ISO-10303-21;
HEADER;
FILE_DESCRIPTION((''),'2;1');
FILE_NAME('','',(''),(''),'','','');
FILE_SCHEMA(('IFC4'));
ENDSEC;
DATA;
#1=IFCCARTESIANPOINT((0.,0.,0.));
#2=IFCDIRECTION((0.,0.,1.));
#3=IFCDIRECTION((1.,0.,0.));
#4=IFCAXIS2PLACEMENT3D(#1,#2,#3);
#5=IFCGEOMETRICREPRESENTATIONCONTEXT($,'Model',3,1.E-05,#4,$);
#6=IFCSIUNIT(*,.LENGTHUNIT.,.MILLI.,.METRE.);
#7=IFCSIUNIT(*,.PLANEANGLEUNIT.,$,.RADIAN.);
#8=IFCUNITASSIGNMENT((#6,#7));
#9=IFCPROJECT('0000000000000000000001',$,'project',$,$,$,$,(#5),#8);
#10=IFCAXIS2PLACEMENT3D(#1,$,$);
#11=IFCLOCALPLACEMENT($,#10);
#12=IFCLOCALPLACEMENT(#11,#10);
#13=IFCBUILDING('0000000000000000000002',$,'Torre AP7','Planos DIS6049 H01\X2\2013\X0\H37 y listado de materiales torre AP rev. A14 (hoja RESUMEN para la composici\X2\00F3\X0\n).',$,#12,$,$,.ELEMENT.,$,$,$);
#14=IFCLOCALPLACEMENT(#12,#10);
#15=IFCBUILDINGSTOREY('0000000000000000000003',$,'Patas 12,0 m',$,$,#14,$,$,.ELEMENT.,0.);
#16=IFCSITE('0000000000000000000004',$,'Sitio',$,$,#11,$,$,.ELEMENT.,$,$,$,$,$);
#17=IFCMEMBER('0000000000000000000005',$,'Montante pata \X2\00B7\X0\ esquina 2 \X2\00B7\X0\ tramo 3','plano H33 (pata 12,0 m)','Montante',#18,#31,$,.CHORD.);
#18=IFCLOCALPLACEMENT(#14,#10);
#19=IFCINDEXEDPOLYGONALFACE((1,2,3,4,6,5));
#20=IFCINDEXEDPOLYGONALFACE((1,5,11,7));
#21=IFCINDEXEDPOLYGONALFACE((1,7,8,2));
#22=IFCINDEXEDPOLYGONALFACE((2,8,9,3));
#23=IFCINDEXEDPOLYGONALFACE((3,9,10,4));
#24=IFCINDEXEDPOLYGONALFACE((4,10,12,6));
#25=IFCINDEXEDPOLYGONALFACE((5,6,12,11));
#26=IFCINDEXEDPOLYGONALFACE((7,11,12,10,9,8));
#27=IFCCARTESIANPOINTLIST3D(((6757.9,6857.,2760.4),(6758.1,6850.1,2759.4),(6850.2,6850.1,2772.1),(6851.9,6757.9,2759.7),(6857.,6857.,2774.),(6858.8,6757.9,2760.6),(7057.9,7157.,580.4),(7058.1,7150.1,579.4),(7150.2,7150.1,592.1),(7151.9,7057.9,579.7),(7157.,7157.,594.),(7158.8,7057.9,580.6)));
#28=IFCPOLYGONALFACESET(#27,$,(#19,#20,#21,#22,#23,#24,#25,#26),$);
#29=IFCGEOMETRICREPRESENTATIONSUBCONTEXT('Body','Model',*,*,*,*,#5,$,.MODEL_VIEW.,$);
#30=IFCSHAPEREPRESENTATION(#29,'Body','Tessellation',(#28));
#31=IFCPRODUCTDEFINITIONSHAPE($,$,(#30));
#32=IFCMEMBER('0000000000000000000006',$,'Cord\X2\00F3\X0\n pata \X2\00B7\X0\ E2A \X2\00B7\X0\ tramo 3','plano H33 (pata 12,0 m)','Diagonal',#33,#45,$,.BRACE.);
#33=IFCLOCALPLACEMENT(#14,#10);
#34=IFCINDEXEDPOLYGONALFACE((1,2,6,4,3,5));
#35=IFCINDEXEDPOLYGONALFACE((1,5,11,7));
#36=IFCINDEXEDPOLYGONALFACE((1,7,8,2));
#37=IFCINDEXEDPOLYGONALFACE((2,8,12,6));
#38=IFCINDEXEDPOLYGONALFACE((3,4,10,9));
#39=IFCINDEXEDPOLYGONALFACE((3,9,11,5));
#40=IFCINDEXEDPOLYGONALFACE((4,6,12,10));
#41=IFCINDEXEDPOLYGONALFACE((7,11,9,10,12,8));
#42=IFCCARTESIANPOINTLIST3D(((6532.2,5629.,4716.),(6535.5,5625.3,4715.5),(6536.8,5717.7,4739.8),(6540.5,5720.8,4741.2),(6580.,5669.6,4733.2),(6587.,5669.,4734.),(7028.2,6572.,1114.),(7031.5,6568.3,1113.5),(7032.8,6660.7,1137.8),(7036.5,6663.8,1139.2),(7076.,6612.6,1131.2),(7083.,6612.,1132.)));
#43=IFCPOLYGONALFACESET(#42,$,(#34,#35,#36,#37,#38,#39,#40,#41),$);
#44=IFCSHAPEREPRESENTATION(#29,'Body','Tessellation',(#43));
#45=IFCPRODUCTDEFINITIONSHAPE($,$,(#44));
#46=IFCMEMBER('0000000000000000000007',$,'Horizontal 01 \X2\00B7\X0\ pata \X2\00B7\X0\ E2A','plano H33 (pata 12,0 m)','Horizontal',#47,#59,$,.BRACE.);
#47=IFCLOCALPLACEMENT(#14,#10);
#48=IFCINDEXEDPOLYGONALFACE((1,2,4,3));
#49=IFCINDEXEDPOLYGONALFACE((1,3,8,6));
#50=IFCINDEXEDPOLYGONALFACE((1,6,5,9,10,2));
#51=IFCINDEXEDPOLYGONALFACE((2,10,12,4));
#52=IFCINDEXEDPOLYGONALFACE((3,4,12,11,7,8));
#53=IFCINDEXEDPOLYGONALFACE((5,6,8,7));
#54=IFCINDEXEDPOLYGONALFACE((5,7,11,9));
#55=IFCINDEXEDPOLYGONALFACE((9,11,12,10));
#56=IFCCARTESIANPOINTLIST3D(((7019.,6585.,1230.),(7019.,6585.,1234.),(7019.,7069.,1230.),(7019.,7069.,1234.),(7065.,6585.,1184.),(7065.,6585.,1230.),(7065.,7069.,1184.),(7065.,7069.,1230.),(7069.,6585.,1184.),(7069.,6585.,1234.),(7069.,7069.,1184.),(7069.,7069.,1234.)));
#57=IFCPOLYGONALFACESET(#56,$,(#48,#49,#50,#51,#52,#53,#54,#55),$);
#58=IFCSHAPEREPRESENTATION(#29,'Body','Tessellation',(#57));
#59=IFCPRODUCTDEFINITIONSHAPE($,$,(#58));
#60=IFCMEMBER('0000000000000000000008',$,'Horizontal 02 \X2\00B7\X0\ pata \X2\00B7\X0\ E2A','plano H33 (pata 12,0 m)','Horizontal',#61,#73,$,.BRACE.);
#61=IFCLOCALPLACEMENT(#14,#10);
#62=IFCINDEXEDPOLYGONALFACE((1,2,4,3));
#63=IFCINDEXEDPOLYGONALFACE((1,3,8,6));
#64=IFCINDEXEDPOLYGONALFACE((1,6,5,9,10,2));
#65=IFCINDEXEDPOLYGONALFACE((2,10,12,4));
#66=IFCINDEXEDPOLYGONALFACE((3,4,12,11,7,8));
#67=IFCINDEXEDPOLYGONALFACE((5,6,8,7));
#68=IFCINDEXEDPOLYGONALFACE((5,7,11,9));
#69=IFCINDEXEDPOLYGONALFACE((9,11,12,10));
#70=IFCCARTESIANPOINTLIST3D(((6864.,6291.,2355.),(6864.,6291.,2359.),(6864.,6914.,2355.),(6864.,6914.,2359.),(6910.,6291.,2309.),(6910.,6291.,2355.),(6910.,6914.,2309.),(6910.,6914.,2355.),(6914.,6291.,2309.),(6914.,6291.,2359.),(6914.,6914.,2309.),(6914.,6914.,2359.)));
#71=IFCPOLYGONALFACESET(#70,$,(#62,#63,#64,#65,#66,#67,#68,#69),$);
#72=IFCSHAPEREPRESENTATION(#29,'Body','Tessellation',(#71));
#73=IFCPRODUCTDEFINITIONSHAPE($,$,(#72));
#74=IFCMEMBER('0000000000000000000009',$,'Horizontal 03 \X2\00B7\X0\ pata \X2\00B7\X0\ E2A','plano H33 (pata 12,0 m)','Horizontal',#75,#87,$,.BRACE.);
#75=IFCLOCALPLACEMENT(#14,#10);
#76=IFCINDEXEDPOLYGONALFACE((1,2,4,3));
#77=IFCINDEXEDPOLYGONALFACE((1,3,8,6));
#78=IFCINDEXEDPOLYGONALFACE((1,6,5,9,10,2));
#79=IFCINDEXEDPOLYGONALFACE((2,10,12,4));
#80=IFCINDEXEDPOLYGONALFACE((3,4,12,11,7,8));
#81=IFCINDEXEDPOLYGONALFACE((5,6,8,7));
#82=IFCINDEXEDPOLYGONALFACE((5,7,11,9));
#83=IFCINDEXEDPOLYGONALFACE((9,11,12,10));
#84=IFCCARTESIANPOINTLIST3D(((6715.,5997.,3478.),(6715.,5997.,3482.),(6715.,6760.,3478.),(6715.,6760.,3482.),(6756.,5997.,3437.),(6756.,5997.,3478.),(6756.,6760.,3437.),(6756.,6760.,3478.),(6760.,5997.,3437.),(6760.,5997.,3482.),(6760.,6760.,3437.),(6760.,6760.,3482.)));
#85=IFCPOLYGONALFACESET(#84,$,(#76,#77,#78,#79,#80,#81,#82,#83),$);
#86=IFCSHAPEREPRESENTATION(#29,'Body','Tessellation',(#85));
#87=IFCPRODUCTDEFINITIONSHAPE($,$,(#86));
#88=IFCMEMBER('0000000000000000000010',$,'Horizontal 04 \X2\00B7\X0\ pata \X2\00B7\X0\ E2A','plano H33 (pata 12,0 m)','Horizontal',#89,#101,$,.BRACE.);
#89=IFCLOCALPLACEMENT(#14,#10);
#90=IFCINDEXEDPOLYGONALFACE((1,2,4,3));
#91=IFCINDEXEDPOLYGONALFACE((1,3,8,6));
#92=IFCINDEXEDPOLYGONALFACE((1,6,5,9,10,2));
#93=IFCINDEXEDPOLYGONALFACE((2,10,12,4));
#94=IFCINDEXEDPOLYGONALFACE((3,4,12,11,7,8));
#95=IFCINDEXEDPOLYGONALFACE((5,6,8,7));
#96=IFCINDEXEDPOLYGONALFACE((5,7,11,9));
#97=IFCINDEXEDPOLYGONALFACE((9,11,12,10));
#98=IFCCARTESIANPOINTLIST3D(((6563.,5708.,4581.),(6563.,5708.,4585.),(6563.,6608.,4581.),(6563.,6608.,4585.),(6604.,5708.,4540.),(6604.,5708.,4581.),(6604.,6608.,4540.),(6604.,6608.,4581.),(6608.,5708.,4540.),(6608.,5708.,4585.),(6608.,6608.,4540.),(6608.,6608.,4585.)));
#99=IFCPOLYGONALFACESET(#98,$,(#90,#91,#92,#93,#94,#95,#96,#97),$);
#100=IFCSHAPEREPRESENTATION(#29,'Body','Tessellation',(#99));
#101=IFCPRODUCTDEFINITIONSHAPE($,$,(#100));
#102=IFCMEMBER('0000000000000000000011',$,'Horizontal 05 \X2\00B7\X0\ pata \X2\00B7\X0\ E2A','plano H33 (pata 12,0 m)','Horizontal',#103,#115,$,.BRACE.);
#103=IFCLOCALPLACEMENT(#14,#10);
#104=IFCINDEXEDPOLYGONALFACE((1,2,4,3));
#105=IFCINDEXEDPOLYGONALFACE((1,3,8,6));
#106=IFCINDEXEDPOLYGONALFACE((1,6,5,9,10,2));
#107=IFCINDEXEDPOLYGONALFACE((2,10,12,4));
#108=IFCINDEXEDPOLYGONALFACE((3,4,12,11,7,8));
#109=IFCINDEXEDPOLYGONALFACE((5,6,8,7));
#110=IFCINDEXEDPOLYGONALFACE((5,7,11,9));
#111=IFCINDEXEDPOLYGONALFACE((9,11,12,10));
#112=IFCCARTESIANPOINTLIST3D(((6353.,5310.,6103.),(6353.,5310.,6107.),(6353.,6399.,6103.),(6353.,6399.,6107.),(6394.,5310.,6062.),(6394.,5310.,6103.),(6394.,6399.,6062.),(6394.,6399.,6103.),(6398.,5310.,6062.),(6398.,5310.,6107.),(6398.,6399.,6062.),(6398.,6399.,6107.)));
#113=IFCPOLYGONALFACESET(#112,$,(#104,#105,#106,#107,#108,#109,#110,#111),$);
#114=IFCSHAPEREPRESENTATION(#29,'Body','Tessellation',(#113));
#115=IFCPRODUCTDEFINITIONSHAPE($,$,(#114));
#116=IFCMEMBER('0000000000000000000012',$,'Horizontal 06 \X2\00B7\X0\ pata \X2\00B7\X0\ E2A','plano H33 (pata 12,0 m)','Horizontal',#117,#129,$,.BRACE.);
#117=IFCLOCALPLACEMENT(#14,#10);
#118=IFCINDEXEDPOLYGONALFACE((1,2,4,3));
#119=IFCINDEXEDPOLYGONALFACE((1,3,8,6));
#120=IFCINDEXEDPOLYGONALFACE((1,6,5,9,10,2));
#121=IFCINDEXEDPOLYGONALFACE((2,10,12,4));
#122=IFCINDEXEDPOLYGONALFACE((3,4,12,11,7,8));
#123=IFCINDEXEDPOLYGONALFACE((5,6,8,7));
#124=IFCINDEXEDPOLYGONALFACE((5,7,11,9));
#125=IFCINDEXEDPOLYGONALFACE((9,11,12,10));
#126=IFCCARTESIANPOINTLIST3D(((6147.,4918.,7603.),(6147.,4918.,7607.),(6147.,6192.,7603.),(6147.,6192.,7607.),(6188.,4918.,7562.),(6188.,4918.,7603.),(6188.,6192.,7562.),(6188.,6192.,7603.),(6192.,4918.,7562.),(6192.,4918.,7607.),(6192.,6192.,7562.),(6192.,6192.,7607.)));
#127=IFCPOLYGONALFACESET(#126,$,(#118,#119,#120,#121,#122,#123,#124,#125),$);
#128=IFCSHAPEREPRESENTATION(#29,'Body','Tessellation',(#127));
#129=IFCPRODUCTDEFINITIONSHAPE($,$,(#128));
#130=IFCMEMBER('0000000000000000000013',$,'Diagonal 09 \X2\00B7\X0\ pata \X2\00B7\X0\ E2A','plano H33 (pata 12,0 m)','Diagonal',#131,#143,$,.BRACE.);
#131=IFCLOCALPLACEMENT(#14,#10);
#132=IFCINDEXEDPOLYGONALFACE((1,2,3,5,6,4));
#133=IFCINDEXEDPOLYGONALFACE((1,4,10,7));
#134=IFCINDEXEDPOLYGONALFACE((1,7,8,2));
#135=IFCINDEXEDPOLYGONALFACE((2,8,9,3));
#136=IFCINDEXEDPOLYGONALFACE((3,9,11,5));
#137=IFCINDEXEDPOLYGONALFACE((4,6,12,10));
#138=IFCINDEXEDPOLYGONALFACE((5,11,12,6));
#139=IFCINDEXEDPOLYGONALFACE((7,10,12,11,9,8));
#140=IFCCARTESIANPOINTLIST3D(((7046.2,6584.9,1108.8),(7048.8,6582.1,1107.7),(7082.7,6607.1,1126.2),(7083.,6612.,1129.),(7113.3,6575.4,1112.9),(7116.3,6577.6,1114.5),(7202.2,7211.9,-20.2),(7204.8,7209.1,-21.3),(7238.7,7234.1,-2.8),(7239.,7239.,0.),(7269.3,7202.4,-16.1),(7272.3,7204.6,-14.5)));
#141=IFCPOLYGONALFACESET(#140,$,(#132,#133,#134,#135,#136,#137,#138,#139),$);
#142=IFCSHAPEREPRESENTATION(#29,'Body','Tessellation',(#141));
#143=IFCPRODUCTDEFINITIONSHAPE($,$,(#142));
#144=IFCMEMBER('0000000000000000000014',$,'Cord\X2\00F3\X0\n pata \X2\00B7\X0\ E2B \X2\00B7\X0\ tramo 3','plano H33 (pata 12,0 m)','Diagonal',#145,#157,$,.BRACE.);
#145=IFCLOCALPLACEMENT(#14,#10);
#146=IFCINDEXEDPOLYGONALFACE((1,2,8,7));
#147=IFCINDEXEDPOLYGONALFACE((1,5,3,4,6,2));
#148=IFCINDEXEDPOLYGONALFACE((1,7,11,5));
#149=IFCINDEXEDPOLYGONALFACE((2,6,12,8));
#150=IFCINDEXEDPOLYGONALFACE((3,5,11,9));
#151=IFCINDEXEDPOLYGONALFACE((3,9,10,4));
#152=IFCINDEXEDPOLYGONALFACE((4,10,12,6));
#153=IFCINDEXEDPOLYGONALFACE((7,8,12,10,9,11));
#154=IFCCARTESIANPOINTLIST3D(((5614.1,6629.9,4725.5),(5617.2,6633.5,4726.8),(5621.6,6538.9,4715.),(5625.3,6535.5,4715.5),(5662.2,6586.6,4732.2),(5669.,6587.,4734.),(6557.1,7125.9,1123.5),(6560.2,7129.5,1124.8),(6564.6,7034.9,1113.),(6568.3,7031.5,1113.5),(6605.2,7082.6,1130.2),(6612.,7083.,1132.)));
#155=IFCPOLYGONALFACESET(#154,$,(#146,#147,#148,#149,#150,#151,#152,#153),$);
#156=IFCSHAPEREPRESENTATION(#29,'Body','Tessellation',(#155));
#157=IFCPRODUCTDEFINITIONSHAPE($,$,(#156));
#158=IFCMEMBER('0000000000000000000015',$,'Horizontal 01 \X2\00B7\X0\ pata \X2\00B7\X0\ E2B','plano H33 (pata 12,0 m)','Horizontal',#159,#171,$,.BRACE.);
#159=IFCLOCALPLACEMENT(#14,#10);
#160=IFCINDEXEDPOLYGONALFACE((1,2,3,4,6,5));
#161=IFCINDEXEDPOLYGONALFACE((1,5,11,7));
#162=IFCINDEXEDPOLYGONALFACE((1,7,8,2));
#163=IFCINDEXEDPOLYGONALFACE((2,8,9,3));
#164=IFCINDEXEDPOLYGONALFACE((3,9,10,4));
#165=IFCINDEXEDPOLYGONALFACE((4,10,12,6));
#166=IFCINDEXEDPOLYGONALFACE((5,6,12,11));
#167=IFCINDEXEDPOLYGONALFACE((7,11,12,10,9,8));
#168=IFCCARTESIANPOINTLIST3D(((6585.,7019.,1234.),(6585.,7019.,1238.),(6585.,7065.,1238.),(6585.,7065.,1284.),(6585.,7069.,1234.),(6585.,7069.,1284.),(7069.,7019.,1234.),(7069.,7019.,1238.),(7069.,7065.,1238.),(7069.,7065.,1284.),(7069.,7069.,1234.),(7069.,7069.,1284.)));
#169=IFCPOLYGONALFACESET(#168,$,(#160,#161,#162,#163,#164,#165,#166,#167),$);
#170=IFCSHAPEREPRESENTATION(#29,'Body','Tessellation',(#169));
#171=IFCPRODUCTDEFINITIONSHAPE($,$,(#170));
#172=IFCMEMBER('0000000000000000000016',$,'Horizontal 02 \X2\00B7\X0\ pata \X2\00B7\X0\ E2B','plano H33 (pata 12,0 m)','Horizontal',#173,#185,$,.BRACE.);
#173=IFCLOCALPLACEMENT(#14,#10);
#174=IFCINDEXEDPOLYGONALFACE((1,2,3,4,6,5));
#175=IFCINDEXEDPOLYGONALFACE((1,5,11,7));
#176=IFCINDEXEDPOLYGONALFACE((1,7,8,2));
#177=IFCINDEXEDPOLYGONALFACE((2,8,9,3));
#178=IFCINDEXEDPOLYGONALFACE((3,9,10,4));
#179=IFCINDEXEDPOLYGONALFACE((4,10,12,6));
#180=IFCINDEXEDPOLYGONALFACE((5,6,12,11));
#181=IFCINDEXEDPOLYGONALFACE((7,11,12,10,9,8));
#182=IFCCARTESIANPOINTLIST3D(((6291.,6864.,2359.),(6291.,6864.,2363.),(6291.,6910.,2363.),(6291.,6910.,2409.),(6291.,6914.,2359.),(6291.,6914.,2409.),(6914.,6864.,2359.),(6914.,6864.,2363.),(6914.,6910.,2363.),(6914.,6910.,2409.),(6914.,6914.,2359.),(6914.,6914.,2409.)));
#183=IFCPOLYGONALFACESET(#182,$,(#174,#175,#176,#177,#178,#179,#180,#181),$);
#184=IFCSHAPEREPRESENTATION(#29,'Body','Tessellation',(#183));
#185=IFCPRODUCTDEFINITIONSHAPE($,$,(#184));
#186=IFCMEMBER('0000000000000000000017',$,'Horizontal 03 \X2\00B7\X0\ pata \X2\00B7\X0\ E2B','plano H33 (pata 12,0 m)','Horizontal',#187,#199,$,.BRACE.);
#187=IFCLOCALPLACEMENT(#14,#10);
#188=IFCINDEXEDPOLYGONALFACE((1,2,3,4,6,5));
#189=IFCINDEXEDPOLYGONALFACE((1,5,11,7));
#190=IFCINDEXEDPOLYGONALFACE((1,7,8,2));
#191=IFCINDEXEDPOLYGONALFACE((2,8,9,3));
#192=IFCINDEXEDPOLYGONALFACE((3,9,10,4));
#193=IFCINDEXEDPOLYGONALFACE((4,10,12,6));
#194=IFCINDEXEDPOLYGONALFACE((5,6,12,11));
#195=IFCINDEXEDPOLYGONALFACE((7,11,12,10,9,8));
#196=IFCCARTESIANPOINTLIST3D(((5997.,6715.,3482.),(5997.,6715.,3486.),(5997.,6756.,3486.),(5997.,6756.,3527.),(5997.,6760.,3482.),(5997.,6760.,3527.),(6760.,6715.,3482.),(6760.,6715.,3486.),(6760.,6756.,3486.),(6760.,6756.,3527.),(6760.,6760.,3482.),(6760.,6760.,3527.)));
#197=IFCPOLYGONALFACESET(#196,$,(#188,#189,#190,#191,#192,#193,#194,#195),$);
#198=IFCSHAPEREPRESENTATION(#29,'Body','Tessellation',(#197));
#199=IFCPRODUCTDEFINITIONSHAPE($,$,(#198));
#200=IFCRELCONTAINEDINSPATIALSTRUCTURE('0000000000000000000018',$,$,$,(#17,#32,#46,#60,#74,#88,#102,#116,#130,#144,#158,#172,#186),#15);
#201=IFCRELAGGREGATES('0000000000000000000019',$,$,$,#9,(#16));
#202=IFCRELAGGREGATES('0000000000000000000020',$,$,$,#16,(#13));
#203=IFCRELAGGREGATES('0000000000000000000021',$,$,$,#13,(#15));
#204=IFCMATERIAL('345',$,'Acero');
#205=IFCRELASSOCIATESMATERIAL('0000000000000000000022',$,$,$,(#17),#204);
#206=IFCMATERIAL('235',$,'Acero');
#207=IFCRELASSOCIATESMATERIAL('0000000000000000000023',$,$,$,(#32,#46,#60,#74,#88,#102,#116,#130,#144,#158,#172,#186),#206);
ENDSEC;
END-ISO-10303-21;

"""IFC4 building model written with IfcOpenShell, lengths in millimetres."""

from ifc_helpers import new_model, si_unit, frame, frame_2d, origin, origin_with_axes, place, context, subcontext, project, spatial, l_section, extrude, material, element, save


model = new_model("IFC4")

# Units and contexts
model_context = context("Model", 3, precision=1e-05, world=origin_with_axes())
body_context = subcontext(model_context, "Body", "Model", "MODEL_VIEW")
ifc_project = project(units=[si_unit("LENGTHUNIT", "METRE", prefix="MILLI"), si_unit("PLANEANGLEUNIT", "RADIAN")], contexts=[model_context])

# Site, building, storey
site_placement = place(None, origin())
site = spatial("IfcSite", under=ifc_project, at=site_placement, Name="Sitio", CompositionType="ELEMENT")
building_placement = place(site_placement, origin())
building = spatial("IfcBuilding", under=site, at=building_placement, Name="Torre AP7", Description="Planos DIS6049 H01–H37 y listado de materiales torre AP rev. A14 (hoja RESUMEN para la composición).", CompositionType="ELEMENT")
storey_placement = place(building_placement, origin())
storey = spatial("IfcBuildingStorey", under=building, at=storey_placement, Name="Patas 12,0 m", CompositionType="ELEMENT", Elevation=0.0)

# Members
ifc_material_1 = material(Name="345", Category="Acero")
member_1_placement = place(storey_placement, frame((6857.0, 6857.0, 2774.0), z_axis=(0.13508, 0.13508, -0.981584), x_axis=(0.018415, -0.990835, -0.133819)))
element("IfcMember", 1, at=member_1_placement, inside=storey, material=ifc_material_1, Name="Montante pata · esquina 2 · tramo 3", Description="plano H33 (pata 12,0 m)", ObjectType="Montante", PredefinedType="CHORD", context=body_context, shape_type="SweptSolid", body=[
    extrude(l_section(Depth=100.0, Width=100.0, Thickness=7.0, at=frame_2d((50.0, 50.0))), None, (0.0, 0.0, 1.0), 2220.9),
])
ifc_material_2 = material(Name="235", Category="Acero")
member_2_placement = place(storey_placement, frame((6587.0, 5669.0, 4734.0), z_axis=(0.132045, 0.251046, -0.958926), x_axis=(-0.735254, -0.624006, -0.26461)))
element("IfcMember", 2, at=member_2_placement, inside=storey, material=ifc_material_2, Name="Cordón pata · E2A · tramo 3", Description="plano H33 (pata 12,0 m)", ObjectType="Diagonal", PredefinedType="BRACE", context=body_context, shape_type="SweptSolid", body=[
    extrude(l_section(Depth=70.0, Width=70.0, Thickness=5.0, at=frame_2d((35.0, 35.0))), None, (0.0, 0.0, 1.0), 3756.3),
])
member_3_placement = place(storey_placement, frame((7069.0, 7069.0, 1234.0), z_axis=(0.0, -1.0, 0.0), x_axis=(-1.0, 0.0, 0.0)))
element("IfcMember", 3, at=member_3_placement, inside=storey, material=ifc_material_2, Name="Horizontal 01 · pata · E2A", Description="plano H33 (pata 12,0 m)", ObjectType="Horizontal", PredefinedType="BRACE", context=body_context, shape_type="SweptSolid", body=[
    extrude(l_section(Depth=50.0, Width=50.0, Thickness=4.0, at=frame_2d((25.0, 25.0))), None, (0.0, 0.0, 1.0), 484.0),
])
member_4_placement = place(storey_placement, frame((6914.0, 6914.0, 2359.0), z_axis=(0.0, -1.0, 0.0), x_axis=(-1.0, 0.0, 0.0)))
element("IfcMember", 4, at=member_4_placement, inside=storey, material=ifc_material_2, Name="Horizontal 02 · pata · E2A", Description="plano H33 (pata 12,0 m)", ObjectType="Horizontal", PredefinedType="BRACE", context=body_context, shape_type="SweptSolid", body=[
    extrude(l_section(Depth=50.0, Width=50.0, Thickness=4.0, at=frame_2d((25.0, 25.0))), None, (0.0, 0.0, 1.0), 623.0),
])
member_5_placement = place(storey_placement, frame((6760.0, 6760.0, 3482.0), z_axis=(0.0, -1.0, 0.0), x_axis=(-1.0, 0.0, 0.0)))
element("IfcMember", 5, at=member_5_placement, inside=storey, material=ifc_material_2, Name="Horizontal 03 · pata · E2A", Description="plano H33 (pata 12,0 m)", ObjectType="Horizontal", PredefinedType="BRACE", context=body_context, shape_type="SweptSolid", body=[
    extrude(l_section(Depth=45.0, Width=45.0, Thickness=4.0, at=frame_2d((22.5, 22.5))), None, (0.0, 0.0, 1.0), 763.0),
])
member_6_placement = place(storey_placement, frame((6608.0, 6608.0, 4585.0), z_axis=(0.0, -1.0, 0.0), x_axis=(-1.0, 0.0, 0.0)))
element("IfcMember", 6, at=member_6_placement, inside=storey, material=ifc_material_2, Name="Horizontal 04 · pata · E2A", Description="plano H33 (pata 12,0 m)", ObjectType="Horizontal", PredefinedType="BRACE", context=body_context, shape_type="SweptSolid", body=[
    extrude(l_section(Depth=45.0, Width=45.0, Thickness=4.0, at=frame_2d((22.5, 22.5))), None, (0.0, 0.0, 1.0), 900.0),
])
member_7_placement = place(storey_placement, frame((6398.0, 6399.0, 6107.0), z_axis=(0.0, -1.0, 0.0), x_axis=(-1.0, 0.0, 0.0)))
element("IfcMember", 7, at=member_7_placement, inside=storey, material=ifc_material_2, Name="Horizontal 05 · pata · E2A", Description="plano H33 (pata 12,0 m)", ObjectType="Horizontal", PredefinedType="BRACE", context=body_context, shape_type="SweptSolid", body=[
    extrude(l_section(Depth=45.0, Width=45.0, Thickness=4.0, at=frame_2d((22.5, 22.5))), None, (0.0, 0.0, 1.0), 1089.0),
])
member_8_placement = place(storey_placement, frame((6192.0, 6192.0, 7607.0), z_axis=(0.0, -1.0, 0.0), x_axis=(-1.0, 0.0, 0.0)))
element("IfcMember", 8, at=member_8_placement, inside=storey, material=ifc_material_2, Name="Horizontal 06 · pata · E2A", Description="plano H33 (pata 12,0 m)", ObjectType="Horizontal", PredefinedType="BRACE", context=body_context, shape_type="SweptSolid", body=[
    extrude(l_section(Depth=45.0, Width=45.0, Thickness=4.0, at=frame_2d((22.5, 22.5))), None, (0.0, 0.0, 1.0), 1274.0),
])
member_9_placement = place(storey_placement, frame((7239.0, 7239.0, 0.0), z_axis=(-0.119925, -0.482007, 0.867921), x_axis=(-0.73689, -0.542627, -0.403173)))
element("IfcMember", 9, at=member_9_placement, inside=storey, material=ifc_material_2, Name="Diagonal 09 · pata · E2A", Description="plano H33 (pata 12,0 m)", ObjectType="Diagonal", PredefinedType="BRACE", context=body_context, shape_type="SweptSolid", body=[
    extrude(l_section(Depth=50.0, Width=50.0, Thickness=4.0, at=frame_2d((25.0, 25.0))), None, (0.0, 0.0, 1.0), 1300.8),
])
member_10_placement = place(storey_placement, frame((5669.0, 6587.0, 4734.0), z_axis=(0.251046, 0.132045, -0.958926), x_axis=(-0.624006, -0.735254, -0.26461)))
element("IfcMember", 10, at=member_10_placement, inside=storey, material=ifc_material_2, Name="Cordón pata · E2B · tramo 3", Description="plano H33 (pata 12,0 m)", ObjectType="Diagonal", PredefinedType="BRACE", context=body_context, shape_type="SweptSolid", body=[
    extrude(l_section(Depth=70.0, Width=70.0, Thickness=5.0, at=frame_2d((35.0, 35.0))), None, (0.0, 0.0, 1.0), 3756.3),
])
member_11_placement = place(storey_placement, frame((7069.0, 7069.0, 1234.0), z_axis=(-1.0, 0.0, 0.0), x_axis=(0.0, -1.0, 0.0)))
element("IfcMember", 11, at=member_11_placement, inside=storey, material=ifc_material_2, Name="Horizontal 01 · pata · E2B", Description="plano H33 (pata 12,0 m)", ObjectType="Horizontal", PredefinedType="BRACE", context=body_context, shape_type="SweptSolid", body=[
    extrude(l_section(Depth=50.0, Width=50.0, Thickness=4.0, at=frame_2d((25.0, 25.0))), None, (0.0, 0.0, 1.0), 484.0),
])
member_12_placement = place(storey_placement, frame((6914.0, 6914.0, 2359.0), z_axis=(-1.0, 0.0, 0.0), x_axis=(0.0, -1.0, 0.0)))
element("IfcMember", 12, at=member_12_placement, inside=storey, material=ifc_material_2, Name="Horizontal 02 · pata · E2B", Description="plano H33 (pata 12,0 m)", ObjectType="Horizontal", PredefinedType="BRACE", context=body_context, shape_type="SweptSolid", body=[
    extrude(l_section(Depth=50.0, Width=50.0, Thickness=4.0, at=frame_2d((25.0, 25.0))), None, (0.0, 0.0, 1.0), 623.0),
])
member_13_placement = place(storey_placement, frame((6760.0, 6760.0, 3482.0), z_axis=(-1.0, 0.0, 0.0), x_axis=(0.0, -1.0, 0.0)))
element("IfcMember", 13, at=member_13_placement, inside=storey, material=ifc_material_2, Name="Horizontal 03 · pata · E2B", Description="plano H33 (pata 12,0 m)", ObjectType="Horizontal", PredefinedType="BRACE", context=body_context, shape_type="SweptSolid", body=[
    extrude(l_section(Depth=45.0, Width=45.0, Thickness=4.0, at=frame_2d((22.5, 22.5))), None, (0.0, 0.0, 1.0), 763.0),
])

save(model, "model.ifc")
